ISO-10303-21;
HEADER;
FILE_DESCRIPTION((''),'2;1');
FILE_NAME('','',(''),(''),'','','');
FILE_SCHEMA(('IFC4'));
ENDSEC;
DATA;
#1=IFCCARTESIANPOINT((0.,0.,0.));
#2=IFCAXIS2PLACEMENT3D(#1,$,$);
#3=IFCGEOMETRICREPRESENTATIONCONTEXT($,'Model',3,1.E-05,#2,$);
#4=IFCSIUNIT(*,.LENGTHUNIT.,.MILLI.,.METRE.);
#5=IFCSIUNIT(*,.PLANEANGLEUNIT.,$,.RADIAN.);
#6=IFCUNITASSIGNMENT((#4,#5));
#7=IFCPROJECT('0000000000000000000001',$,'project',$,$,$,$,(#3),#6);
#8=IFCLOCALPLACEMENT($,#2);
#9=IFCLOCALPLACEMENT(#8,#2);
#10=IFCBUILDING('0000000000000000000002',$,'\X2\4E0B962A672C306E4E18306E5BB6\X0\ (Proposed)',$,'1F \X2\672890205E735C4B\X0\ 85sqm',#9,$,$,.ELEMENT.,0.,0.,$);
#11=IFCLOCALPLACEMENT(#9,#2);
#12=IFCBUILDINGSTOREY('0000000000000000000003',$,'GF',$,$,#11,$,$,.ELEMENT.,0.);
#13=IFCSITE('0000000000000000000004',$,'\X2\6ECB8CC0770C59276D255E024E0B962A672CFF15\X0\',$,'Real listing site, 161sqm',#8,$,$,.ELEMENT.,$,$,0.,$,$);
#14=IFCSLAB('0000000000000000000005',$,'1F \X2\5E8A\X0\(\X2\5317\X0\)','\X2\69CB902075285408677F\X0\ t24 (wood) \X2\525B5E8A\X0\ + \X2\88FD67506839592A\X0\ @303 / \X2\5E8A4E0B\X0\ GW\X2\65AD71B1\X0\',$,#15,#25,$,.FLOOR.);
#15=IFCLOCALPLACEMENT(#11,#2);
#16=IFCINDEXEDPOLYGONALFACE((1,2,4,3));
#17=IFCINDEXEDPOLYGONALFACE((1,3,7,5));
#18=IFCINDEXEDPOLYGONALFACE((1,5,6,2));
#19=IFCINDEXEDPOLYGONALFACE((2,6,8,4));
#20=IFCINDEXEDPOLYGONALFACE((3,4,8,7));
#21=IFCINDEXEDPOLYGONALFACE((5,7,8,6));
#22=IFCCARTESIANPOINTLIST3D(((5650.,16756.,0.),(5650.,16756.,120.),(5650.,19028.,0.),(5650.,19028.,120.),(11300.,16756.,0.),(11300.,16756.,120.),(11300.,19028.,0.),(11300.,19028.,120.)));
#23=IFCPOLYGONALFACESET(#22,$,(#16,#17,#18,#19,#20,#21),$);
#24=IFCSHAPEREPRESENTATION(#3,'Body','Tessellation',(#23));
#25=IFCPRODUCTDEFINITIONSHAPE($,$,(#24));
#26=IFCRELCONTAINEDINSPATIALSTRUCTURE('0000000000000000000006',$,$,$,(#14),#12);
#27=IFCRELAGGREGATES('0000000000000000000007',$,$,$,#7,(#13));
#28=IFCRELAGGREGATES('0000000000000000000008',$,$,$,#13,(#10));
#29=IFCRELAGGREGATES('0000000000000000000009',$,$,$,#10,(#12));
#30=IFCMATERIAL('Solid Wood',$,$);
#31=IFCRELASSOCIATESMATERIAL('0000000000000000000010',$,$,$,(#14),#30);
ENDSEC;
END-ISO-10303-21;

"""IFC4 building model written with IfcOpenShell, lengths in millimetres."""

from ifc_helpers import new_model, si_unit, frame, frame_2d, origin, place, context, project, spatial, rectangle, extrude, material, element, save


model = new_model("IFC4")

# Units and contexts
model_context = context("Model", 3, precision=1e-05, world=origin())
ifc_project = project(units=[si_unit("LENGTHUNIT", "METRE", prefix="MILLI"), si_unit("PLANEANGLEUNIT", "RADIAN")], contexts=[model_context])

# Site, building, storey
site_placement = place(None, origin())
site = spatial("IfcSite", under=ifc_project, at=site_placement, Name="滋賀県大津市下阪本５", ObjectType="Real listing site, 161sqm", CompositionType="ELEMENT", RefElevation=0.0)
building_placement = place(site_placement, origin())
building = spatial("IfcBuilding", under=site, at=building_placement, Name="下阪本の丘の家 (Proposed)", ObjectType="1F 木造平屋 85sqm", CompositionType="ELEMENT", ElevationOfRefHeight=0.0, ElevationOfTerrain=0.0)
storey_placement = place(building_placement, origin())
storey = spatial("IfcBuildingStorey", under=building, at=storey_placement, Name="GF", CompositionType="ELEMENT", Elevation=0.0)

# Slab
ifc_material_1 = material(Name="Solid Wood")
slab_1_placement = place(storey_placement, frame((2825.0, 8378.0, 0.0)))
element("IfcSlab", 1, at=slab_1_placement, inside=storey, material=ifc_material_1, Name="1F 床(北)", Description="構造用合板 t24 (wood) 剛床 + 製材根太 @303 / 床下 GW断熱", PredefinedType="FLOOR", context=model_context, shape_type="SweptSolid", body=[
    extrude(rectangle(XDim=5650.0, YDim=2272.0, at=frame_2d((2825.0, 1136.0))), frame((2825.0, 8378.0, 0.0)), (0.0, 0.0, 1.0), 120.0),
])

save(model, "model.ifc")
